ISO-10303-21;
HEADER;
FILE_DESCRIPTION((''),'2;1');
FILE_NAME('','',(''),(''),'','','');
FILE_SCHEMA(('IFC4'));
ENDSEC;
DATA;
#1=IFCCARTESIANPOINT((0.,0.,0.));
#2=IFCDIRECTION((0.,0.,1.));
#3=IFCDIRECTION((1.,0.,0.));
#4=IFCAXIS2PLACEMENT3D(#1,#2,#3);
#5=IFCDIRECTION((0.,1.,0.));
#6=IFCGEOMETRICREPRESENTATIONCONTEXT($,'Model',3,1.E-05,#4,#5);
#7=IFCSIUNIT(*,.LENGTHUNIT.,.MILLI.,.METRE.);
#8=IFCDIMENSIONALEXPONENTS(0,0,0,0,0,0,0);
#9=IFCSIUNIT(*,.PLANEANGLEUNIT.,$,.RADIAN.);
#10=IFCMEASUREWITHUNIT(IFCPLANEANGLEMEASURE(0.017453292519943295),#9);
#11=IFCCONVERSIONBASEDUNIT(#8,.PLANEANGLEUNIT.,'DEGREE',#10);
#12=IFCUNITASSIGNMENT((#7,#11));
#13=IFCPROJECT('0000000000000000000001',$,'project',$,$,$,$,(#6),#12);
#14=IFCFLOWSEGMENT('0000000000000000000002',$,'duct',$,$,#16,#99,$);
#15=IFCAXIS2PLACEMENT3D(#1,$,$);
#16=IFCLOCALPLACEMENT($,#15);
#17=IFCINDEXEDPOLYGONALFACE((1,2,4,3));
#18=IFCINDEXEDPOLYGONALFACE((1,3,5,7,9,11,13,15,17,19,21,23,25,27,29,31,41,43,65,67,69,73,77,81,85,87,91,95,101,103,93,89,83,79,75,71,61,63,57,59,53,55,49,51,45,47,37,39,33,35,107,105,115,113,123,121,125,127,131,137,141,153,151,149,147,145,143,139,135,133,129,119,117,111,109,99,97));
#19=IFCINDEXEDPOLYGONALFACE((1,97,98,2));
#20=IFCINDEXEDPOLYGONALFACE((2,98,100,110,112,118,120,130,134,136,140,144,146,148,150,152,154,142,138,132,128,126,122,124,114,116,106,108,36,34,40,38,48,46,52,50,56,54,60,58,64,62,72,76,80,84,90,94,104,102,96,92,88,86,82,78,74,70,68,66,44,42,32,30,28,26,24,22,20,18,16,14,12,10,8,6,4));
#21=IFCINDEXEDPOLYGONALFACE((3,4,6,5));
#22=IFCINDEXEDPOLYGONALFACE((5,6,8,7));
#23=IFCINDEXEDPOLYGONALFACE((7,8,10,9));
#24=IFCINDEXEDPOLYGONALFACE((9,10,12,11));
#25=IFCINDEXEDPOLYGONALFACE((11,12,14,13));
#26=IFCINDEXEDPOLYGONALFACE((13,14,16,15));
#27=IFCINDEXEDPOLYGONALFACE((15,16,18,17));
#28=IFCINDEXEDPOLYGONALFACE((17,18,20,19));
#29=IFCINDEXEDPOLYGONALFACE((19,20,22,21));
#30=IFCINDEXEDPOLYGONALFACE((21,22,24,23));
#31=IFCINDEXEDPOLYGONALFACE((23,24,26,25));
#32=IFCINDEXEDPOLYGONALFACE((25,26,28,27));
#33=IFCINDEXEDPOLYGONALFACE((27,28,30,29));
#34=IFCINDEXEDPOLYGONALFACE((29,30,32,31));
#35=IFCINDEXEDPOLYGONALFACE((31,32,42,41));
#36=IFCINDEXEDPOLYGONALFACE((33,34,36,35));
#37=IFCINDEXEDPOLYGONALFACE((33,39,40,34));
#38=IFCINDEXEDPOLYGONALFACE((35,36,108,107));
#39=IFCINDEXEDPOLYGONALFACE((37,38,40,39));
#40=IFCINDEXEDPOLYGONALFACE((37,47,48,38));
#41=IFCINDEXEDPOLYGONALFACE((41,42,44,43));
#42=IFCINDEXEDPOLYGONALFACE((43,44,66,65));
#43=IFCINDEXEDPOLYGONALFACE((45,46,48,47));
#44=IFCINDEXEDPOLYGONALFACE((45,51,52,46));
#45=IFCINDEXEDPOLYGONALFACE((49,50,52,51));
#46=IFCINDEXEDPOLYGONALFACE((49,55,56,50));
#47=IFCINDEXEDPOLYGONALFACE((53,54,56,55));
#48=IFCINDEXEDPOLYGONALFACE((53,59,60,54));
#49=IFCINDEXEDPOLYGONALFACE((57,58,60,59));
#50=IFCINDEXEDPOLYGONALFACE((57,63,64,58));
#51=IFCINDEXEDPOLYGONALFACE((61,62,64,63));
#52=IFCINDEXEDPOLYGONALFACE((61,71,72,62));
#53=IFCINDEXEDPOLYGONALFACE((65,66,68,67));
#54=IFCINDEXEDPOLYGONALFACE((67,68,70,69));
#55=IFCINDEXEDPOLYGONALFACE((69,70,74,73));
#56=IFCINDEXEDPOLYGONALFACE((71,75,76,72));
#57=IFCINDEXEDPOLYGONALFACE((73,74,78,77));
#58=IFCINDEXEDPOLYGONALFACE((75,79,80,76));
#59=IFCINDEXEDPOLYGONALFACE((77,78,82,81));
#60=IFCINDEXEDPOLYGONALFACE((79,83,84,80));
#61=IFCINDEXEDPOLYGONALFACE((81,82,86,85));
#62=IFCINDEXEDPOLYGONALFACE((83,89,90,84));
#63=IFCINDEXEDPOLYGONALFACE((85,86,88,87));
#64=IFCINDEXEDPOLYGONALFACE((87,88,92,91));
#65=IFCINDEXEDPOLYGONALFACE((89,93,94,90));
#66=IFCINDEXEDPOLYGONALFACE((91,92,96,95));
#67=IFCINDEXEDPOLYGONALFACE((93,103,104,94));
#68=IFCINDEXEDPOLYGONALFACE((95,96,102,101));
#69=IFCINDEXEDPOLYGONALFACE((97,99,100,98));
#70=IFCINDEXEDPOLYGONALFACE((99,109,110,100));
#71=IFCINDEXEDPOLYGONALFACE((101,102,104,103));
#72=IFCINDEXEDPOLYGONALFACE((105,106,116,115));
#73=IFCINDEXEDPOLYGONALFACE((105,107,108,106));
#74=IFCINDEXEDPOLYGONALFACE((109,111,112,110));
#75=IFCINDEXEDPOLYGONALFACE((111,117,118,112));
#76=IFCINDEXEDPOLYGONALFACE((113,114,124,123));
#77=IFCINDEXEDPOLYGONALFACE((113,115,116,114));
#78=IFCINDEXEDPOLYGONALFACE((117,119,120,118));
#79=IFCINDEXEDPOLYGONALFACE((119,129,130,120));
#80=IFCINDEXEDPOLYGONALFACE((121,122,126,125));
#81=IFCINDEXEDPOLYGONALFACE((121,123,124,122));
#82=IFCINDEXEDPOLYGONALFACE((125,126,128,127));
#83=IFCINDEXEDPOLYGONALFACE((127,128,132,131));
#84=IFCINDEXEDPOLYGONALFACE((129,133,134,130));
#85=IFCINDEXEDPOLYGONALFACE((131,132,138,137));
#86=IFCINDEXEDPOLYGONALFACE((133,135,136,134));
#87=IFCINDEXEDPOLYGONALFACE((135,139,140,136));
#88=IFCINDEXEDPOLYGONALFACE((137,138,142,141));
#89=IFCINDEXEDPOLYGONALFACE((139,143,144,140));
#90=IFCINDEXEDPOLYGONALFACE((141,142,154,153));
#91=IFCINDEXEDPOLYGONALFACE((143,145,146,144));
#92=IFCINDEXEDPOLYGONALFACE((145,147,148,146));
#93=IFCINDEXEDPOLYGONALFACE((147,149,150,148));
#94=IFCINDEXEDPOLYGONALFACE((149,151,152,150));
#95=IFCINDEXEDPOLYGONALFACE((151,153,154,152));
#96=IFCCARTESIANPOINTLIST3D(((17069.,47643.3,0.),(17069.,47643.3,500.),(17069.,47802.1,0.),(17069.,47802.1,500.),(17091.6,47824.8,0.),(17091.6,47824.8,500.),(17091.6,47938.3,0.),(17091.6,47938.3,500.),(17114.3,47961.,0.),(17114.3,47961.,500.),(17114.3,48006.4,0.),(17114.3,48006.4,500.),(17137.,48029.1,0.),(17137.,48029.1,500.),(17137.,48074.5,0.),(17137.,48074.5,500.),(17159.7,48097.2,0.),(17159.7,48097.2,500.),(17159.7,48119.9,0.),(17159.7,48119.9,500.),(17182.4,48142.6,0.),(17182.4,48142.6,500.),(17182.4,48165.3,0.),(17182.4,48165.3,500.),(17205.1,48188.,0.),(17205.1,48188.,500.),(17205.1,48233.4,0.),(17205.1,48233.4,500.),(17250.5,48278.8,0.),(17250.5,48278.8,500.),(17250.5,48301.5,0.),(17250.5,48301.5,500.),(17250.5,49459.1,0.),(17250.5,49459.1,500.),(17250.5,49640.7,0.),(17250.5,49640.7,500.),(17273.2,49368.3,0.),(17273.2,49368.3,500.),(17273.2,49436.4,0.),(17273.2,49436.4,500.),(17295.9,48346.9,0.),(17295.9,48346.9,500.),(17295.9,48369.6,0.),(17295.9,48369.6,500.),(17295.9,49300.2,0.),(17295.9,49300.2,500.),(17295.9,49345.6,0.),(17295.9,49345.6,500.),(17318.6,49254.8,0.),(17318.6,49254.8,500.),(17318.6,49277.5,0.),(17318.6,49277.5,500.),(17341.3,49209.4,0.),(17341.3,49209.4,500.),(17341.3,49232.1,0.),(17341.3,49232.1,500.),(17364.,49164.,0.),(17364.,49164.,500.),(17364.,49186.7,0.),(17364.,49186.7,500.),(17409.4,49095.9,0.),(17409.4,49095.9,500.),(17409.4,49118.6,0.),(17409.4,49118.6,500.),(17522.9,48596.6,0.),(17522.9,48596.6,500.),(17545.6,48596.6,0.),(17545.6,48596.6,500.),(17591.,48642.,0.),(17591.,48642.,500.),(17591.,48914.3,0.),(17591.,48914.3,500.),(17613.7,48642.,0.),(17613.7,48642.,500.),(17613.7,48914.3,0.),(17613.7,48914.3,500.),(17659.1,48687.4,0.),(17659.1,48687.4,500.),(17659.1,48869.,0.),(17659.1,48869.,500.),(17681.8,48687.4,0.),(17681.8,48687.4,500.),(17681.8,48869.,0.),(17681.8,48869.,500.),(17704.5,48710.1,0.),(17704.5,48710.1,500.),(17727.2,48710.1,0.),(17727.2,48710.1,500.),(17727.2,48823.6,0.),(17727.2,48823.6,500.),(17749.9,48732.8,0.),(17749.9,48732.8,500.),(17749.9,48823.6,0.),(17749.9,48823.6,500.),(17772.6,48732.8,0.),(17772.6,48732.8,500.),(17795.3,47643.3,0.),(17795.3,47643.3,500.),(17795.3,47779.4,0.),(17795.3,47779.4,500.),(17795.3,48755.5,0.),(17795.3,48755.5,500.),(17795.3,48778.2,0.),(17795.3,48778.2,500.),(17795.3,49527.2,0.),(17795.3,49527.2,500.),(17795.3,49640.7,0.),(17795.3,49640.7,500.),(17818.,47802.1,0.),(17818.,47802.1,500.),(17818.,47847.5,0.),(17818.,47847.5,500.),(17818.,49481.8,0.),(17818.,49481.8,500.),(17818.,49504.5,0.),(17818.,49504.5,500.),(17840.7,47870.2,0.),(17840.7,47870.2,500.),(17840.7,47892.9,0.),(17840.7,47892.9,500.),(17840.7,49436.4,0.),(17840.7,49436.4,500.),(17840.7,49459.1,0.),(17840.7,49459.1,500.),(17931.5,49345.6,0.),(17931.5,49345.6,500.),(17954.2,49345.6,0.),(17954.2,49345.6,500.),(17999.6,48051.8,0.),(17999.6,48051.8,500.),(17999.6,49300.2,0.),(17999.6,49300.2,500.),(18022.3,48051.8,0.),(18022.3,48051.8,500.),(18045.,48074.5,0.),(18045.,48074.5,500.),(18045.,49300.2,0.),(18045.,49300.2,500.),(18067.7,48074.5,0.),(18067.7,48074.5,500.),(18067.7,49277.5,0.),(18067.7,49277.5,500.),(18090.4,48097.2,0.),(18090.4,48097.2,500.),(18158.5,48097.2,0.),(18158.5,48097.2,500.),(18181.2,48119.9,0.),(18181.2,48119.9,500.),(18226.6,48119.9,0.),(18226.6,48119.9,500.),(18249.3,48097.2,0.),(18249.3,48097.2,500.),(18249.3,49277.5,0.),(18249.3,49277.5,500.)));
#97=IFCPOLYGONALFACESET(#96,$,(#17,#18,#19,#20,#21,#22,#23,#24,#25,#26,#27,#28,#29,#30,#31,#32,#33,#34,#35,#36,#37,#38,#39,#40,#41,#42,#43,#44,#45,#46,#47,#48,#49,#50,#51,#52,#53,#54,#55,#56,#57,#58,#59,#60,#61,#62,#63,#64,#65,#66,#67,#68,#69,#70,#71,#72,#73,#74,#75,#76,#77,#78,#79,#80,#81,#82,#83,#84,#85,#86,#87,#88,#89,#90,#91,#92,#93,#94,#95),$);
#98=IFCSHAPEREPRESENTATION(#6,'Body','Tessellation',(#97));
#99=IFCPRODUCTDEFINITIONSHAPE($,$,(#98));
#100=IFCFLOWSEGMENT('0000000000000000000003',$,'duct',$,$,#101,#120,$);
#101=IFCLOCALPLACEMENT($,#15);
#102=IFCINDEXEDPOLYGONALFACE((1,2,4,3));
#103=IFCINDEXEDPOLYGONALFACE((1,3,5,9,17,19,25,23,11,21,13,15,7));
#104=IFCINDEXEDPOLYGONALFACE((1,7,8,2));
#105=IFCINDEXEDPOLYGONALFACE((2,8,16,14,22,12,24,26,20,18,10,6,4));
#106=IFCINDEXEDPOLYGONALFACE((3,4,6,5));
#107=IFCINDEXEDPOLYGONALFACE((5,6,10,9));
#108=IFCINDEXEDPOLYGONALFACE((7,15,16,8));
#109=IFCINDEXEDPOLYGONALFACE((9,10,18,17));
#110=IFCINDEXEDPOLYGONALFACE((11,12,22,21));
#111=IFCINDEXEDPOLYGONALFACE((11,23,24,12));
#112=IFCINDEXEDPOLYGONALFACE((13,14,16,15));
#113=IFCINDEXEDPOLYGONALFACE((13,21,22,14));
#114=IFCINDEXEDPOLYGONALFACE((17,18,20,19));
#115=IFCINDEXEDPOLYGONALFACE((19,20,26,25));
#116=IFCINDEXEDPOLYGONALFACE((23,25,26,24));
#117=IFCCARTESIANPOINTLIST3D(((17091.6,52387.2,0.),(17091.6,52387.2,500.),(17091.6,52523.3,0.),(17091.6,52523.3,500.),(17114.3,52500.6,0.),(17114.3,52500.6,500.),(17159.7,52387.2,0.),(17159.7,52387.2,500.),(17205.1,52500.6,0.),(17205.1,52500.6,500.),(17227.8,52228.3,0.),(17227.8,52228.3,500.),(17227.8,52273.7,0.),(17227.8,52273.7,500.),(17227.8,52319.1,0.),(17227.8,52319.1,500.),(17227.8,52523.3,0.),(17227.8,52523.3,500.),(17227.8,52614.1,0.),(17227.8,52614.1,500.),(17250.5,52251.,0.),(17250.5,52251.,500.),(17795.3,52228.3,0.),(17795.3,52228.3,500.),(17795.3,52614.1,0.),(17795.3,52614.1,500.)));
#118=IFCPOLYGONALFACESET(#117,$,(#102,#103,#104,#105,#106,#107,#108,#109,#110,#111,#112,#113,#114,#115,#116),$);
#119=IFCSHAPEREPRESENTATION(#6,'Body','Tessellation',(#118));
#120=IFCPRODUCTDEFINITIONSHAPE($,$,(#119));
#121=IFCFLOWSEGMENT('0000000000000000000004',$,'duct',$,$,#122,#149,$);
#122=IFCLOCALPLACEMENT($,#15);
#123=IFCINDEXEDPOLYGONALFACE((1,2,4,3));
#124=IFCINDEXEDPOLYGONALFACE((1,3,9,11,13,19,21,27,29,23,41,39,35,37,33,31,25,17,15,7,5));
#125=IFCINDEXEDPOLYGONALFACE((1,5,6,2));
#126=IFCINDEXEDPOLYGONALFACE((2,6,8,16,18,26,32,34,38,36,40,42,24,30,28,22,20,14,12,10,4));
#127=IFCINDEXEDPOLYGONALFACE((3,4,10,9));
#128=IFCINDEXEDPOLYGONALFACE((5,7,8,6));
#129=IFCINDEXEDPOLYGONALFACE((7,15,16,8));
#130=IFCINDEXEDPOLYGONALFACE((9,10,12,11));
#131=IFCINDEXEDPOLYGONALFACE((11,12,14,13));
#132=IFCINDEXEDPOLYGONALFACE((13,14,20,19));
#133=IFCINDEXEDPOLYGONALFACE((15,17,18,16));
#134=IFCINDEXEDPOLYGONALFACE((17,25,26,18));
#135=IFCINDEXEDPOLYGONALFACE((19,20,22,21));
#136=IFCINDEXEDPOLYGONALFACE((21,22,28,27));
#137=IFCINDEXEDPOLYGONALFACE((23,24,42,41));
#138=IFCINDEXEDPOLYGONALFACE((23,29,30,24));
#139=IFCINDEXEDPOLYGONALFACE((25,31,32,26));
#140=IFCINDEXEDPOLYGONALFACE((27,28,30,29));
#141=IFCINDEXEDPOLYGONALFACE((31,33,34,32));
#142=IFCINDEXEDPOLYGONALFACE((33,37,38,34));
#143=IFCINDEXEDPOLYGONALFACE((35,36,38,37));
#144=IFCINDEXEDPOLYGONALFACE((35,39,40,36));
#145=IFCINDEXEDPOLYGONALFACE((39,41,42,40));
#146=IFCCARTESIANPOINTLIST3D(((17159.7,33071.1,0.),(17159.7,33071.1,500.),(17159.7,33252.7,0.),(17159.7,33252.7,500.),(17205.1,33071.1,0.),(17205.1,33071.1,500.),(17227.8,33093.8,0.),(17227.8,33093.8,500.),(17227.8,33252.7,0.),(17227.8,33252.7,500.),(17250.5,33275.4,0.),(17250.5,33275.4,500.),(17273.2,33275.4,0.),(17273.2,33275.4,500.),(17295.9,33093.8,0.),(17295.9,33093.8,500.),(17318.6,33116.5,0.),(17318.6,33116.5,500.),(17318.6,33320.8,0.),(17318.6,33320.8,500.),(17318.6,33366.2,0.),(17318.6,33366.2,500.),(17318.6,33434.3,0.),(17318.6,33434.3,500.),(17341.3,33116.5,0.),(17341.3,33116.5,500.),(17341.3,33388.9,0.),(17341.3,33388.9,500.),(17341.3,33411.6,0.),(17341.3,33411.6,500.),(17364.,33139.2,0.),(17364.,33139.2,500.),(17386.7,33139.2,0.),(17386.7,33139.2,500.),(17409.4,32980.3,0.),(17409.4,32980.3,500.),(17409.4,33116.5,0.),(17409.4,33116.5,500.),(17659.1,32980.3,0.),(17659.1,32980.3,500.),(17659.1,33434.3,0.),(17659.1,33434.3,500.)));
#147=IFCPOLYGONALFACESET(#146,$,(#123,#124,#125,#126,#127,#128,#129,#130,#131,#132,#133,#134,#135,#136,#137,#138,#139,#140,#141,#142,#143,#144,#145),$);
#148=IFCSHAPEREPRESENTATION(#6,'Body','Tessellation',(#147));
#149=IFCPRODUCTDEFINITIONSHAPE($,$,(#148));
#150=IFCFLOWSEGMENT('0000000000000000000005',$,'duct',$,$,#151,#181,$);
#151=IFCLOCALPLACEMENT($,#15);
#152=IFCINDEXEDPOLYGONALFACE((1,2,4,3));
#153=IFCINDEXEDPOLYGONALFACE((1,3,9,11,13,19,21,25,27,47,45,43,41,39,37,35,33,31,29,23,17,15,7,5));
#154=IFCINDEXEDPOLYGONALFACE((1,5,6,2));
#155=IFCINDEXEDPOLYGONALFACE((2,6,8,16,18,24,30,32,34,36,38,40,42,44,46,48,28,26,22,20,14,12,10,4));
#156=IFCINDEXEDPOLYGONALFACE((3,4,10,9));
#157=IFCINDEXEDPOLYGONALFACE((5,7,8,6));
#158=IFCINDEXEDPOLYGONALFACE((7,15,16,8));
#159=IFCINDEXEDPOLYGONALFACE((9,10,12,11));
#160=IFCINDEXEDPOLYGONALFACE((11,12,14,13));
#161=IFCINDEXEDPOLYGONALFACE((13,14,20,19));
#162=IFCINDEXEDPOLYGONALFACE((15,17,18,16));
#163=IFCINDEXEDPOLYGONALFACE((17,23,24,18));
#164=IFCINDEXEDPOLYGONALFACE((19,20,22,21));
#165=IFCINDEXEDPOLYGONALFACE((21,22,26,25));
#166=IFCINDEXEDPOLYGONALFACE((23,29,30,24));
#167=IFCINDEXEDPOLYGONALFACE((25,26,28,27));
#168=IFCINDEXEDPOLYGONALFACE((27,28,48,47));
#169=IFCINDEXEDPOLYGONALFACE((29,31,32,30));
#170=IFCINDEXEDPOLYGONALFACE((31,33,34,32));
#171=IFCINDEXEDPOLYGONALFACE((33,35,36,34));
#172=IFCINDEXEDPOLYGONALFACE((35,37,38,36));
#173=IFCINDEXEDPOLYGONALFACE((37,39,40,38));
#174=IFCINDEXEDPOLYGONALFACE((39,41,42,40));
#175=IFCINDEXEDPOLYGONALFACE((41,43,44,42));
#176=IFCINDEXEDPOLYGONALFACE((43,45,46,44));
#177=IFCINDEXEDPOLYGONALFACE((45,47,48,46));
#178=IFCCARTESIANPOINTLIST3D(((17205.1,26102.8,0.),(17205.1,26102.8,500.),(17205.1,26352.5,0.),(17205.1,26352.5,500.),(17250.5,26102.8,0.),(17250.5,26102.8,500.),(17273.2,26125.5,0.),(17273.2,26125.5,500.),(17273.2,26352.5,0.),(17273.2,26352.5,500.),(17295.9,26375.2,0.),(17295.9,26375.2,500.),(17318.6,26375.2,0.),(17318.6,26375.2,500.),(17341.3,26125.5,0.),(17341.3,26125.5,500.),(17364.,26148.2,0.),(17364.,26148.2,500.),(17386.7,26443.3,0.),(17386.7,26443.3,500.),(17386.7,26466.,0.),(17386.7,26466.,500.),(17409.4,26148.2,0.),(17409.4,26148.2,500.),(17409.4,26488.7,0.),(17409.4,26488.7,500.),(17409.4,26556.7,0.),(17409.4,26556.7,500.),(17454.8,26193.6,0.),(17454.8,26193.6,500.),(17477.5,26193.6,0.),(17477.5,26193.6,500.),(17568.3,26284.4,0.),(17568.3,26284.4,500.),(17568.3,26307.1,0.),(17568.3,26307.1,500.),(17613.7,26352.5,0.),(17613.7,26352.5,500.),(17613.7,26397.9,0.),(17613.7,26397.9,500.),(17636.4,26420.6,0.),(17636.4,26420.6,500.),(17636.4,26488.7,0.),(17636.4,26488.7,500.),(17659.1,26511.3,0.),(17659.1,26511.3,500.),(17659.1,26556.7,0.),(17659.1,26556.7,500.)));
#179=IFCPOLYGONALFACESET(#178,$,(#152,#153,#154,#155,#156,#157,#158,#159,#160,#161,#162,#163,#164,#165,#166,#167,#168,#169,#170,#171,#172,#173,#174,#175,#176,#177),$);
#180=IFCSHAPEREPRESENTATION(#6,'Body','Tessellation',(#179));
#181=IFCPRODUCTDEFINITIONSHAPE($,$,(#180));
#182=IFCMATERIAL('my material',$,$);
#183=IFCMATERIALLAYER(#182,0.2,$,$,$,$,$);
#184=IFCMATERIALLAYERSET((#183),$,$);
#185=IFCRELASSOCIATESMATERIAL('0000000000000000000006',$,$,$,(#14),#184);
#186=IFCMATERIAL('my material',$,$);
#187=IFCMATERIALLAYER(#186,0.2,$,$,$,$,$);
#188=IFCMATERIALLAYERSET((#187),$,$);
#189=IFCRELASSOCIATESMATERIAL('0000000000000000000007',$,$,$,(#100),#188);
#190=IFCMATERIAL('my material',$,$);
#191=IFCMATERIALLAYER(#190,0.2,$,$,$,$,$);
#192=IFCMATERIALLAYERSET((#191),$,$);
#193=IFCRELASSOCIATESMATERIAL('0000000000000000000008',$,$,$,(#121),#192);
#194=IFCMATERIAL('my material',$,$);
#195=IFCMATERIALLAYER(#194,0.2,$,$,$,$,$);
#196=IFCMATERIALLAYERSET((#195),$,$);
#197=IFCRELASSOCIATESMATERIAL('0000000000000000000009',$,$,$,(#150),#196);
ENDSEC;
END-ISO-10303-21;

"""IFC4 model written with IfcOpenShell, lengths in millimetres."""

from ifc_helpers import new_model, entity, si_unit, converted_unit, direction, origin_with_axes, place, context, project, polyline, outline, extrude, material, layer, layer_set, layer_usage, element, save


model = new_model("IFC4")

# Units and contexts
model_context = context("Model", 3, precision=1e-05, world=origin_with_axes(), true_north=direction((0.0, 1.0, 0.0)))
ifc_project = project(units=[si_unit("LENGTHUNIT", "METRE", prefix="MILLI"), converted_unit("PLANEANGLEUNIT", "DEGREE", entity("IfcPlaneAngleMeasure", 0.017453292519943295), si_unit("PLANEANGLEUNIT", "RADIAN"), dimensions=[0, 0, 0, 0, 0, 0, 0])], contexts=[model_context])

# Flow segments
ifc_material_1 = material(Name="my material")
ifc_layer_1 = layer(ifc_material_1, 0.2)
ifc_layer_set_1 = layer_set([ifc_layer_1])
ifc_layer_usage_1 = layer_usage(ifc_layer_set_1, "AXIS2", "POSITIVE", -0.1)
flow_segment_1_placement = place(None, origin_with_axes())
element("IfcFlowSegment", 1, at=flow_segment_1_placement, material=ifc_layer_usage_1, Name="duct", context=model_context, shape_type="SweptSolid", body=[
    extrude(outline(polyline([(17069.0, 47643.3), (17795.3, 47643.3), (17795.3, 47779.4), (17818.0, 47802.1), (17818.0, 47847.5), (17840.7, 47870.2), (17840.7, 47892.9), (17999.6, 48051.8), (18022.3, 48051.8), (18045.0, 48074.5), (18067.7, 48074.5), (18090.4, 48097.2), (18158.5, 48097.2), (18181.2, 48119.9), (18226.6, 48119.9), (18249.3, 48097.2), (18249.3, 49277.5), (18067.7, 49277.5), (18045.0, 49300.2), (17999.6, 49300.2), (17954.2, 49345.6), (17931.5, 49345.6), (17840.7, 49436.4), (17840.7, 49459.1), (17818.0, 49481.8), (17818.0, 49504.5), (17795.3, 49527.2), (17795.3, 49640.7), (17250.5, 49640.7), (17250.5, 49459.1), (17273.2, 49436.4), (17273.2, 49368.3), (17295.9, 49345.6), (17295.9, 49300.2), (17318.6, 49277.5), (17318.6, 49254.8), (17341.3, 49232.1), (17341.3, 49209.4), (17364.0, 49186.7), (17364.0, 49164.0), (17409.4, 49118.6), (17409.4, 49095.9), (17591.0, 48914.3), (17613.7, 48914.3), (17659.1, 48869.0), (17681.8, 48869.0), (17727.2, 48823.6), (17749.9, 48823.6), (17795.3, 48778.2), (17795.3, 48755.5), (17772.6, 48732.8), (17749.9, 48732.8), (17727.2, 48710.1), (17704.5, 48710.1), (17681.8, 48687.4), (17659.1, 48687.4), (17613.7, 48642.0), (17591.0, 48642.0), (17545.6, 48596.6), (17522.9, 48596.6), (17295.9, 48369.6), (17295.9, 48346.9), (17250.5, 48301.5), (17250.5, 48278.8), (17205.1, 48233.4), (17205.1, 48188.0), (17182.4, 48165.3), (17182.4, 48142.6), (17159.7, 48119.9), (17159.7, 48097.2), (17137.0, 48074.5), (17137.0, 48029.1), (17114.3, 48006.4), (17114.3, 47961.0), (17091.6, 47938.3), (17091.6, 47824.8), (17069.0, 47802.1), (17069.0, 47643.3)])), origin_with_axes(), (0.0, 0.0, 1.0), 500.0),
])
ifc_material_2 = material(Name="my material")
ifc_layer_2 = layer(ifc_material_2, 0.2)
ifc_layer_set_2 = layer_set([ifc_layer_2])
ifc_layer_usage_2 = layer_usage(ifc_layer_set_2, "AXIS2", "POSITIVE", -0.1)
flow_segment_2_placement = place(None, origin_with_axes())
element("IfcFlowSegment", 2, at=flow_segment_2_placement, material=ifc_layer_usage_2, Name="duct", context=model_context, shape_type="SweptSolid", body=[
    extrude(outline(polyline([(17091.6, 52387.2), (17159.7, 52387.2), (17227.8, 52319.1), (17227.8, 52273.7), (17250.5, 52251.0), (17227.8, 52228.3), (17795.3, 52228.3), (17795.3, 52614.1), (17227.8, 52614.1), (17227.8, 52523.3), (17205.1, 52500.6), (17114.3, 52500.6), (17091.6, 52523.3), (17091.6, 52387.2)])), origin_with_axes(), (0.0, 0.0, 1.0), 500.0),
])
ifc_material_3 = material(Name="my material")
ifc_layer_3 = layer(ifc_material_3, 0.2)
ifc_layer_set_3 = layer_set([ifc_layer_3])
ifc_layer_usage_3 = layer_usage(ifc_layer_set_3, "AXIS2", "POSITIVE", -0.1)
flow_segment_3_placement = place(None, origin_with_axes())
element("IfcFlowSegment", 3, at=flow_segment_3_placement, material=ifc_layer_usage_3, Name="duct", context=model_context, shape_type="SweptSolid", body=[
    extrude(outline(polyline([(17159.7, 33071.1), (17205.1, 33071.1), (17227.8, 33093.8), (17295.9, 33093.8), (17318.6, 33116.5), (17341.3, 33116.5), (17364.0, 33139.2), (17386.7, 33139.2), (17409.4, 33116.5), (17409.4, 32980.3), (17659.1, 32980.3), (17659.1, 33434.3), (17318.6, 33434.3), (17341.3, 33411.6), (17341.3, 33388.9), (17318.6, 33366.2), (17318.6, 33320.8), (17273.2, 33275.4), (17250.5, 33275.4), (17227.8, 33252.7), (17159.7, 33252.7), (17159.7, 33071.1)])), origin_with_axes(), (0.0, 0.0, 1.0), 500.0),
])
ifc_material_4 = material(Name="my material")
ifc_layer_4 = layer(ifc_material_4, 0.2)
ifc_layer_set_4 = layer_set([ifc_layer_4])
ifc_layer_usage_4 = layer_usage(ifc_layer_set_4, "AXIS2", "POSITIVE", -0.1)
flow_segment_4_placement = place(None, origin_with_axes())
element("IfcFlowSegment", 4, at=flow_segment_4_placement, material=ifc_layer_usage_4, Name="duct", context=model_context, shape_type="SweptSolid", body=[
    extrude(outline(polyline([(17205.1, 26102.8), (17250.5, 26102.8), (17273.2, 26125.5), (17341.3, 26125.5), (17364.0, 26148.2), (17409.4, 26148.2), (17454.8, 26193.6), (17477.5, 26193.6), (17568.3, 26284.4), (17568.3, 26307.1), (17613.7, 26352.5), (17613.7, 26397.9), (17636.4, 26420.6), (17636.4, 26488.7), (17659.1, 26511.3), (17659.1, 26556.7), (17409.4, 26556.7), (17409.4, 26488.7), (17386.7, 26466.0), (17386.7, 26443.3), (17318.6, 26375.2), (17295.9, 26375.2), (17273.2, 26352.5), (17205.1, 26352.5), (17205.1, 26102.8)])), origin_with_axes(), (0.0, 0.0, 1.0), 500.0),
])

save(model, "model.ifc")
